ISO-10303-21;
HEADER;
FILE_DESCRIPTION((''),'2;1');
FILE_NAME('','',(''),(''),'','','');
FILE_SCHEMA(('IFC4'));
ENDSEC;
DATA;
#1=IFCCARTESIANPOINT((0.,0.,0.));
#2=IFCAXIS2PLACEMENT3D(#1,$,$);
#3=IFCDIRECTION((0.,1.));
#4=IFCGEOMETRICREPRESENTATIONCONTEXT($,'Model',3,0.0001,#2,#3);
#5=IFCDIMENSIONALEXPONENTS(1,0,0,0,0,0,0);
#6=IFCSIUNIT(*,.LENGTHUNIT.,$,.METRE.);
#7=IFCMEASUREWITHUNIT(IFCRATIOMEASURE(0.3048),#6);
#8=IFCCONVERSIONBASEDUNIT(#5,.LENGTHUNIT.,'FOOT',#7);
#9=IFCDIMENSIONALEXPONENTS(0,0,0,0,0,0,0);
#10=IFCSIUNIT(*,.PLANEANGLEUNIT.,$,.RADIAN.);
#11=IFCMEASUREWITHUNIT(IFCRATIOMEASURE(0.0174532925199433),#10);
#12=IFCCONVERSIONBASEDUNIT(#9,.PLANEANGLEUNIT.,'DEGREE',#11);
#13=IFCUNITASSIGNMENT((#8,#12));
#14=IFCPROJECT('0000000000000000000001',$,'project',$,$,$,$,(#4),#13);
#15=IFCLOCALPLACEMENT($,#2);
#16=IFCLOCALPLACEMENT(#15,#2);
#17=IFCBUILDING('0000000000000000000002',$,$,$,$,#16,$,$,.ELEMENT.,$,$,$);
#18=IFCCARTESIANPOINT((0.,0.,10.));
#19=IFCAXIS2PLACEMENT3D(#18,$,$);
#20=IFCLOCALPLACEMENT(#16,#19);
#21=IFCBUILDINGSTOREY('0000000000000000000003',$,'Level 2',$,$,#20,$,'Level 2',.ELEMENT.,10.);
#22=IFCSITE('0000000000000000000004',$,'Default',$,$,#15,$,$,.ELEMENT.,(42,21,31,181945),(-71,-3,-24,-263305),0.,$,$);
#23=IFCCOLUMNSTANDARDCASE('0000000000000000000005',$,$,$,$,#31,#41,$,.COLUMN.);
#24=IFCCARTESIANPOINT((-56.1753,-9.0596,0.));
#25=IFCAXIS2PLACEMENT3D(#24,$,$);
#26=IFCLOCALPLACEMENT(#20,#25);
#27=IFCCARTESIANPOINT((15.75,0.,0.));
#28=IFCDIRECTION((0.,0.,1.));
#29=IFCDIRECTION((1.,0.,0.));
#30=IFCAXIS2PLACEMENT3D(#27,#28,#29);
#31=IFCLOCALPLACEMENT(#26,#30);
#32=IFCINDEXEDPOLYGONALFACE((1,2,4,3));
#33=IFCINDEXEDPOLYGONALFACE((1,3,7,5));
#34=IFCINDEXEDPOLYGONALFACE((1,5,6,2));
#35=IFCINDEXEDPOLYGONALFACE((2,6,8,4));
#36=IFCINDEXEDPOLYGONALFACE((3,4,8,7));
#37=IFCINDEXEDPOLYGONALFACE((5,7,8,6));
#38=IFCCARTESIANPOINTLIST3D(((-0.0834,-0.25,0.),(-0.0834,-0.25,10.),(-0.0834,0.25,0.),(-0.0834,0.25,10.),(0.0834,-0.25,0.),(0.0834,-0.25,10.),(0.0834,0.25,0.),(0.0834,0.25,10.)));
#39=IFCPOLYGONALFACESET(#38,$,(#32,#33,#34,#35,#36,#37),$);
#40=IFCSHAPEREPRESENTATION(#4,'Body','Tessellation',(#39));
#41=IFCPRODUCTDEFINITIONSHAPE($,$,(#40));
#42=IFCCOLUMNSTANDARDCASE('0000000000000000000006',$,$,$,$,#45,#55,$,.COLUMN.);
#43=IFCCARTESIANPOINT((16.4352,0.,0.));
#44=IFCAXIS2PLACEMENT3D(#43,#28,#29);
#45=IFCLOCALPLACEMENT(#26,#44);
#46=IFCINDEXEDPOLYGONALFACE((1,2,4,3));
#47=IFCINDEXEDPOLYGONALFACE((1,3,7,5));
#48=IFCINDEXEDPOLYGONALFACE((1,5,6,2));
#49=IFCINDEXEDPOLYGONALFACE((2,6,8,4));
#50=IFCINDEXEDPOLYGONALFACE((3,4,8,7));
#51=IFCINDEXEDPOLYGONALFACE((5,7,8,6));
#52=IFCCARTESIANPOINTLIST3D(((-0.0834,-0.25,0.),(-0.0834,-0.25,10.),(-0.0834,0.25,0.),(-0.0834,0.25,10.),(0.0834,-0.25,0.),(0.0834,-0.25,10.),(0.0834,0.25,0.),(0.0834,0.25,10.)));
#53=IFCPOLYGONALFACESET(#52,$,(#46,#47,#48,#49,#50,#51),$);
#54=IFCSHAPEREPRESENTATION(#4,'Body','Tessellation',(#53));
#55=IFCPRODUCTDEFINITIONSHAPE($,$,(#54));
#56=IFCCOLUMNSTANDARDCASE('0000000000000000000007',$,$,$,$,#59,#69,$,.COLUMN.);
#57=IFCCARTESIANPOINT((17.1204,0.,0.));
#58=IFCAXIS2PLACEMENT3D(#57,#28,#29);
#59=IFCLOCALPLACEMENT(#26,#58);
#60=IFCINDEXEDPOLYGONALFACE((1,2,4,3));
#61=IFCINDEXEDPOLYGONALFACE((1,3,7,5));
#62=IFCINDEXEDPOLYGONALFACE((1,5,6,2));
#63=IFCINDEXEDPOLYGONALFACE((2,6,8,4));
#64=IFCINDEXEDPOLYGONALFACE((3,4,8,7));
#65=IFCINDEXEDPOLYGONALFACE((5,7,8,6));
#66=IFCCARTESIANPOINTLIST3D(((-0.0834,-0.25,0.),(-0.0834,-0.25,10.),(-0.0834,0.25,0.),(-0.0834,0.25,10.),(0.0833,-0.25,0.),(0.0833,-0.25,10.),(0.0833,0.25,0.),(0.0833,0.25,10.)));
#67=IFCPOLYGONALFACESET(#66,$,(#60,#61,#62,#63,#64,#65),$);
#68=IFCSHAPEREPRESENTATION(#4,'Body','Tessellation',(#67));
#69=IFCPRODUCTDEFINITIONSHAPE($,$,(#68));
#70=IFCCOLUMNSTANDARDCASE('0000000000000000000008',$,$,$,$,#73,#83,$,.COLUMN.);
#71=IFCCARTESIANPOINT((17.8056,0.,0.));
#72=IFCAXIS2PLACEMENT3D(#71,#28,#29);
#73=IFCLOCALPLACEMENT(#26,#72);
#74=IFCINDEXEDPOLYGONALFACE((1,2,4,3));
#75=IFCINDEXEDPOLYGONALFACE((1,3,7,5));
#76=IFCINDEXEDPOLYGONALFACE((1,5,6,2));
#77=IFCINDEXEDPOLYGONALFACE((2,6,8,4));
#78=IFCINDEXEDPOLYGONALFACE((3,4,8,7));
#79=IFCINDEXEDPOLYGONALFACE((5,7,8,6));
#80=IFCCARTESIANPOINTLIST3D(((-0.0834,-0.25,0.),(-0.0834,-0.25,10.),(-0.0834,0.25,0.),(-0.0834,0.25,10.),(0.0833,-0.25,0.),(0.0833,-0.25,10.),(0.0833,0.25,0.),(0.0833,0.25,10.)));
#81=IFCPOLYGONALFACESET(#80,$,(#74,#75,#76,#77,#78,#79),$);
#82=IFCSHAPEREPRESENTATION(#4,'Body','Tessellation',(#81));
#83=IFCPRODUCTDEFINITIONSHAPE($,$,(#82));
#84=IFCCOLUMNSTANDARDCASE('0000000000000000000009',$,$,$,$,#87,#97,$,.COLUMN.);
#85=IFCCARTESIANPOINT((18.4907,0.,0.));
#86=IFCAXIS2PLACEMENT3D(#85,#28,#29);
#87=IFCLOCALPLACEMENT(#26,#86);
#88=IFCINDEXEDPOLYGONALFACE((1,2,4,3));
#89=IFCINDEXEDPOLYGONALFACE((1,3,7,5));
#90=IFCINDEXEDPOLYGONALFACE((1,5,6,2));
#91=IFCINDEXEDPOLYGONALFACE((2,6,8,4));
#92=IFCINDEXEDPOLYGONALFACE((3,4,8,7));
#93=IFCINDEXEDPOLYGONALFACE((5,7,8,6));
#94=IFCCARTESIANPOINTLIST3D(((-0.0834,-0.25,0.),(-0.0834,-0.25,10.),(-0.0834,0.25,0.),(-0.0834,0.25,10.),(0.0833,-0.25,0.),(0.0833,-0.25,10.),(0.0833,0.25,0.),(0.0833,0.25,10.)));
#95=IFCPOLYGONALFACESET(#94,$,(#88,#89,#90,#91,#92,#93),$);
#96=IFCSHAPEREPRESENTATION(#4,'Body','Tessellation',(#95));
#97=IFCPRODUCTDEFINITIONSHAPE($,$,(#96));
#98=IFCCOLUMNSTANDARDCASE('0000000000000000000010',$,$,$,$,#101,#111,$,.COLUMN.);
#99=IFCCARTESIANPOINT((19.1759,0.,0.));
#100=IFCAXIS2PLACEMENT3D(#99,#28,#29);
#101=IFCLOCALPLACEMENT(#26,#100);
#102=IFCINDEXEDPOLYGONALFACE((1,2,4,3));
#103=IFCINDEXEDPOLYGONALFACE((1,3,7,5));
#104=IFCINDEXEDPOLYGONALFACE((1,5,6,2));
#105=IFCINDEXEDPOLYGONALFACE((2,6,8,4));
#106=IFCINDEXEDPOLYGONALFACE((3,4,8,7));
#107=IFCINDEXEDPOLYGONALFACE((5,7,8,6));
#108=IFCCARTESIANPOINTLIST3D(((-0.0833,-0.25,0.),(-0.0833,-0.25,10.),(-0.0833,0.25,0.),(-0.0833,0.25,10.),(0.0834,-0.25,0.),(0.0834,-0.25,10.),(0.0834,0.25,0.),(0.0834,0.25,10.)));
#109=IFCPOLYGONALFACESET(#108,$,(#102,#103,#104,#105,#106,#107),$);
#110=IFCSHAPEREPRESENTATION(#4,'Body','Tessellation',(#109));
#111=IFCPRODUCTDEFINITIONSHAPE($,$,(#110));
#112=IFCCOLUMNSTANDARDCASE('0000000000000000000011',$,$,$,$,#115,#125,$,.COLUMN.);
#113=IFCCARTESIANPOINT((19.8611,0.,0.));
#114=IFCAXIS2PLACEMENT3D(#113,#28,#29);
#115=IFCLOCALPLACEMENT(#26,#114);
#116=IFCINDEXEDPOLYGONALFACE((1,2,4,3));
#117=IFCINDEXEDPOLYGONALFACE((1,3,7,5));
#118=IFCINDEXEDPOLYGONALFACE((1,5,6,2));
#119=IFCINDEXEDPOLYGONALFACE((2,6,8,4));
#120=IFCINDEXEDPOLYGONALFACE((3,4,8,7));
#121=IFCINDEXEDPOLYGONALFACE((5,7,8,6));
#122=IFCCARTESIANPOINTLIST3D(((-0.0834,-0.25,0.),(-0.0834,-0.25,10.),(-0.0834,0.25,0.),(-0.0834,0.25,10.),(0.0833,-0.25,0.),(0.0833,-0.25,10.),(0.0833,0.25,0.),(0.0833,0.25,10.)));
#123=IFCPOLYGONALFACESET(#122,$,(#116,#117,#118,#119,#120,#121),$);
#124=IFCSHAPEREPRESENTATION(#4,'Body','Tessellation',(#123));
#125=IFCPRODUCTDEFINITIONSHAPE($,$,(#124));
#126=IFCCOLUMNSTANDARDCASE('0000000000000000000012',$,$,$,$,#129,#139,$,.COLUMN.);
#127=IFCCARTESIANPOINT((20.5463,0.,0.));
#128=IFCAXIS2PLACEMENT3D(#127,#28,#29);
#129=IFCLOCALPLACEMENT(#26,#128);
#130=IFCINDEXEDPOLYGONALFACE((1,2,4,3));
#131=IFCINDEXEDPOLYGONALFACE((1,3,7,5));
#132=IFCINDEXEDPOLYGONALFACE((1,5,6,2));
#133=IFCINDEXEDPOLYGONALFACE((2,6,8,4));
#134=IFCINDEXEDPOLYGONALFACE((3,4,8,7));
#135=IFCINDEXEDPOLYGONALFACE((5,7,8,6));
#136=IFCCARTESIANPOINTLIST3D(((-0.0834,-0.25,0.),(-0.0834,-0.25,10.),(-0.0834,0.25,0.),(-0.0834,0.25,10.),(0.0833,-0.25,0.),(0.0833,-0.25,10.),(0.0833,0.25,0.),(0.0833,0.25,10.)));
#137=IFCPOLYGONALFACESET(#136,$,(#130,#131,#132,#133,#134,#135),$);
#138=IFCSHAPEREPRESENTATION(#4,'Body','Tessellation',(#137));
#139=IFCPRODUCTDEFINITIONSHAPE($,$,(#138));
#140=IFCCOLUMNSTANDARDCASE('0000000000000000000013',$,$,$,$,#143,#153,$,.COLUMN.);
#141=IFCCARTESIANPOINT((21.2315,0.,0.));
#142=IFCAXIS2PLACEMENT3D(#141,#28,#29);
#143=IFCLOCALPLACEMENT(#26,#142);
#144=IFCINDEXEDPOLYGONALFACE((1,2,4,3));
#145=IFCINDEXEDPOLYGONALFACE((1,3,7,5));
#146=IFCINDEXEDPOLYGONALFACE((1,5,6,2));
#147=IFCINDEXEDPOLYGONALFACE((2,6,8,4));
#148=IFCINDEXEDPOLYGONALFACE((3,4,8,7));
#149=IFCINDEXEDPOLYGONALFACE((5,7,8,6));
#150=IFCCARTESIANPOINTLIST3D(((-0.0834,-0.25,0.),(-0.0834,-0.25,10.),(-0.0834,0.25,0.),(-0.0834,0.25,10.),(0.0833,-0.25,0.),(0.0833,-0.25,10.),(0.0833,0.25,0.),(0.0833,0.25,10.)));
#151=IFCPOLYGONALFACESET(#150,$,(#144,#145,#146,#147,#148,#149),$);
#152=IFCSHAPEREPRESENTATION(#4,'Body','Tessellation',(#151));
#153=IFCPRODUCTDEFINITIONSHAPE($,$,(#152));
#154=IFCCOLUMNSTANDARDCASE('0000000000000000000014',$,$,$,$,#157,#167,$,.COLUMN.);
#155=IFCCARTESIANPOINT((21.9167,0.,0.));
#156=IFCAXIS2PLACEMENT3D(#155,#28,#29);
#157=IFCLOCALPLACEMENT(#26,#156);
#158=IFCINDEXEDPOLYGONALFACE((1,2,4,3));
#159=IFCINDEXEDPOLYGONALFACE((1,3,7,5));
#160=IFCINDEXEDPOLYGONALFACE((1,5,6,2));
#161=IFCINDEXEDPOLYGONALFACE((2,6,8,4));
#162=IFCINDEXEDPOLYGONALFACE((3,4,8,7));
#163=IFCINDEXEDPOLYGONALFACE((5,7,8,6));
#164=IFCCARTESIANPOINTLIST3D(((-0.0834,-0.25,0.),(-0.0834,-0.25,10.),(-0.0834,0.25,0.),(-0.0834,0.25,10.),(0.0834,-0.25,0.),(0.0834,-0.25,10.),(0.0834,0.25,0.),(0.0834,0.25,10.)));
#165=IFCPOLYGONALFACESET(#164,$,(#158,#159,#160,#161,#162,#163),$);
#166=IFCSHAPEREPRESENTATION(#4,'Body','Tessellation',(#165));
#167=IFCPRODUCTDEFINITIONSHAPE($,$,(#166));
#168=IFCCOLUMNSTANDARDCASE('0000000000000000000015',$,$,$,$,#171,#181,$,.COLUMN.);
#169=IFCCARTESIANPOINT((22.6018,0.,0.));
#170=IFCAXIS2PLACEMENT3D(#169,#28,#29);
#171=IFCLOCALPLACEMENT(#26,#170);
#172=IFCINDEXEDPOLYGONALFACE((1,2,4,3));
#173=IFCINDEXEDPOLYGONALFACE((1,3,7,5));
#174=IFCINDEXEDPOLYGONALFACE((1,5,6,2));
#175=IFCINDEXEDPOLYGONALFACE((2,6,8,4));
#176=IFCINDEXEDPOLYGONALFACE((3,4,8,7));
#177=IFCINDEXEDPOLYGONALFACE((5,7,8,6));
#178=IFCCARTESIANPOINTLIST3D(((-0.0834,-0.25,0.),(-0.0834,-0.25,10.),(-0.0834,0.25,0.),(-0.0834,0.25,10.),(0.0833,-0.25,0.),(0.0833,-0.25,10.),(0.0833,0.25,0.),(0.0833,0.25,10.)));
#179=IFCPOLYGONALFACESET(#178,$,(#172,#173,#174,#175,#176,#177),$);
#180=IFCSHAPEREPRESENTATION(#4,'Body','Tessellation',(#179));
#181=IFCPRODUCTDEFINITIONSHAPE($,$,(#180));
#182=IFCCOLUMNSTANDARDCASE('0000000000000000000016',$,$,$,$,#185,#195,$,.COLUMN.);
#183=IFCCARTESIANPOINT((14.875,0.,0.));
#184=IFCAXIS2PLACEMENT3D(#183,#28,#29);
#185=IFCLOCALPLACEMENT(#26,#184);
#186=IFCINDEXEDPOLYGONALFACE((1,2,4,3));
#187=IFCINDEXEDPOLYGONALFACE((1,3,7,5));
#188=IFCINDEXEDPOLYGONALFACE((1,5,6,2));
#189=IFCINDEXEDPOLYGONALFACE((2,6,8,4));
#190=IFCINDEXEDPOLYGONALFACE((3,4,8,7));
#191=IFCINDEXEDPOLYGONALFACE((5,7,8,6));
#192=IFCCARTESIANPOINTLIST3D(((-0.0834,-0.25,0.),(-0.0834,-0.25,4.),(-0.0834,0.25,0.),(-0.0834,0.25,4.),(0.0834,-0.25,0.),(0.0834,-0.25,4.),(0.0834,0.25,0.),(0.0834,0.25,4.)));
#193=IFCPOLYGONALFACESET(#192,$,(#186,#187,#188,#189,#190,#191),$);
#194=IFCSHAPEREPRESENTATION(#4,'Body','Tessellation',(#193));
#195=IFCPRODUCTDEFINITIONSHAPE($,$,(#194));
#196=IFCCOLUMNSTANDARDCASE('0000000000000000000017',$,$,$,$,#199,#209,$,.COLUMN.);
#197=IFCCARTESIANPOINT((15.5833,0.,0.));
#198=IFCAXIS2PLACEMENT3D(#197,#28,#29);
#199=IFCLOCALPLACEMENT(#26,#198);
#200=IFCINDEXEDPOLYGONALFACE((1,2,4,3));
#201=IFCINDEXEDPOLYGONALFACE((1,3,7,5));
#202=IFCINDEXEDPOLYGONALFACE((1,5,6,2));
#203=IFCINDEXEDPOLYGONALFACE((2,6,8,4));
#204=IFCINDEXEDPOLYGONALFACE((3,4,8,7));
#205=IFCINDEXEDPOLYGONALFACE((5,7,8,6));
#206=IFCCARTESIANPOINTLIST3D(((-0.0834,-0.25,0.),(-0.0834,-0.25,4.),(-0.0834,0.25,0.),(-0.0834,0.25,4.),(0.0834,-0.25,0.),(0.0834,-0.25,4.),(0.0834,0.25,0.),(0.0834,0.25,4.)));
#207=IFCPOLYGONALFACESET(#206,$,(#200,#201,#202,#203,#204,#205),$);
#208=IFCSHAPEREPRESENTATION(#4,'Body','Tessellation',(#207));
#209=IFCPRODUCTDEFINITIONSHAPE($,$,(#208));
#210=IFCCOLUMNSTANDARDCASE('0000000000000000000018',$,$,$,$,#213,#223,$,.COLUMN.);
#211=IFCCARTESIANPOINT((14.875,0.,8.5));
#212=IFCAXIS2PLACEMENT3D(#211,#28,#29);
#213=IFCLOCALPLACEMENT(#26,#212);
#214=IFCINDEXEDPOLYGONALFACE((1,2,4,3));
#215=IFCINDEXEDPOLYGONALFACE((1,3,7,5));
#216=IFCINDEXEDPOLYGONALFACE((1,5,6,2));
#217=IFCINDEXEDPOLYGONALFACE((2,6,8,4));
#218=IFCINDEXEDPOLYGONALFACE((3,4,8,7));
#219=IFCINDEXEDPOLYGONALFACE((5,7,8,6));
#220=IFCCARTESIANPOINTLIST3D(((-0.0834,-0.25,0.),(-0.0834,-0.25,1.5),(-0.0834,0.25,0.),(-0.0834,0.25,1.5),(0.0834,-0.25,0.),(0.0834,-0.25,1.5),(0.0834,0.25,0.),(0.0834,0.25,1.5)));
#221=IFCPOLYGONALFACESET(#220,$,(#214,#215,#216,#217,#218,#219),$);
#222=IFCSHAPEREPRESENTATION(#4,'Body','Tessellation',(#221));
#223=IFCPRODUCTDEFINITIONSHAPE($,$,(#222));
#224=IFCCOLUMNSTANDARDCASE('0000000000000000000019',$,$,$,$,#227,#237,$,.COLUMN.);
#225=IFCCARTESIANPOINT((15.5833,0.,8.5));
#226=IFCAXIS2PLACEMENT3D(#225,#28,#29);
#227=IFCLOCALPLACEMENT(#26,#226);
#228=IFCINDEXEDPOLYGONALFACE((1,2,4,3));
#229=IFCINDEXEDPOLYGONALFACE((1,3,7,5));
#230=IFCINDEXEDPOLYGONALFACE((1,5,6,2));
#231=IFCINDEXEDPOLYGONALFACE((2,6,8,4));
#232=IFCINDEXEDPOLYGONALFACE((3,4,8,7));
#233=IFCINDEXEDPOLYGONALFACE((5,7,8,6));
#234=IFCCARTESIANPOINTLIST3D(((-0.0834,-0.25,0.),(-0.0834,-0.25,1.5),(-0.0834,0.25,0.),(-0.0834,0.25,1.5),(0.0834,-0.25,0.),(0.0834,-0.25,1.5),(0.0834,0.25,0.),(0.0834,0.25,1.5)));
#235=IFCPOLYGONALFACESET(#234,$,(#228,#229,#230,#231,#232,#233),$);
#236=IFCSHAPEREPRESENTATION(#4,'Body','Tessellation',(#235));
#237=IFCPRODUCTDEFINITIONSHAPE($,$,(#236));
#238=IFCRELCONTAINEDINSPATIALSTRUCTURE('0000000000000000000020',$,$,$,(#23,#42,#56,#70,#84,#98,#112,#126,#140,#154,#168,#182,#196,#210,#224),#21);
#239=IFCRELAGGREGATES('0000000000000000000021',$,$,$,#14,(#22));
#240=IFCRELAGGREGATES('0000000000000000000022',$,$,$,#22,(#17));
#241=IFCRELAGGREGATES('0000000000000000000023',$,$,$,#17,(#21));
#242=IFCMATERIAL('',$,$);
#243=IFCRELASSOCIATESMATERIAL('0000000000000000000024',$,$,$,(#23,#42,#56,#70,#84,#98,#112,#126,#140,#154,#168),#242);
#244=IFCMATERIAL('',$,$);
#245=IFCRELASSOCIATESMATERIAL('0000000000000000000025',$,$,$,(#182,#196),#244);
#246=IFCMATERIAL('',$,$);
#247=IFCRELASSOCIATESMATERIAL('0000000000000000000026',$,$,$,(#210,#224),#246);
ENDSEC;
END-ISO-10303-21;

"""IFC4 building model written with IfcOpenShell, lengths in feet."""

from ifc_helpers import new_model, entity, si_unit, converted_unit, direction, frame, origin, place, context, project, spatial, rectangle, extrude, material, element, save


model = new_model("IFC4")

# Units and contexts
model_context = context("Model", 3, precision=0.0001, world=origin(), true_north=direction((0.0, 1.0)))
ifc_project = project(units=[converted_unit("LENGTHUNIT", "FOOT", entity("IfcRatioMeasure", 0.3048), si_unit("LENGTHUNIT", "METRE"), dimensions=[1, 0, 0, 0, 0, 0, 0]), converted_unit("PLANEANGLEUNIT", "DEGREE", entity("IfcRatioMeasure", 0.0174532925199433), si_unit("PLANEANGLEUNIT", "RADIAN"), dimensions=[0, 0, 0, 0, 0, 0, 0])], contexts=[model_context])

# Site, building, storey
site_placement = place(None, origin())
site = spatial("IfcSite", under=ifc_project, at=site_placement, Name="Default", CompositionType="ELEMENT", RefLatitude=(42, 21, 31, 181945), RefLongitude=(-71, -3, -24, -263305), RefElevation=0.0)
building_placement = place(site_placement, origin())
building = spatial("IfcBuilding", under=site, at=building_placement, CompositionType="ELEMENT")
storey_placement = place(building_placement, frame((0.0, 0.0, 10.0)))
storey = spatial("IfcBuildingStorey", under=building, at=storey_placement, Name="Level 2", LongName="Level 2", CompositionType="ELEMENT", Elevation=10.0)

# Columns
ifc_material_1 = material(Name="")
placement = place(storey_placement, frame((-56.1753, -9.0596, 0.0)))
for number, where, z_axis, x_axis in (
    (1, (15.75, 0.0, 0.0), (0.0, 0.0, 1.0), (1.0, 0.0, 0.0)),
    (2, (16.4352, 0.0, 0.0), (0.0, 0.0, 1.0), (1.0, 0.0, 0.0)),
    (3, (17.1204, 0.0, 0.0), (0.0, 0.0, 1.0), (1.0, 0.0, 0.0)),
    (4, (17.8056, 0.0, 0.0), (0.0, 0.0, 1.0), (1.0, 0.0, 0.0)),
    (5, (18.4907, 0.0, 0.0), (0.0, 0.0, 1.0), (1.0, 0.0, 0.0)),
    (6, (19.1759, 0.0, 0.0), (0.0, 0.0, 1.0), (1.0, 0.0, 0.0)),
    (7, (19.8611, 0.0, 0.0), (0.0, 0.0, 1.0), (1.0, 0.0, 0.0)),
    (8, (20.5463, 0.0, 0.0), (0.0, 0.0, 1.0), (1.0, 0.0, 0.0)),
    (9, (21.2315, 0.0, 0.0), (0.0, 0.0, 1.0), (1.0, 0.0, 0.0)),
    (10, (21.9167, 0.0, 0.0), (0.0, 0.0, 1.0), (1.0, 0.0, 0.0)),
    (11, (22.6018, 0.0, 0.0), (0.0, 0.0, 1.0), (1.0, 0.0, 0.0)),
):
    element("IfcColumnStandardCase", number, at=place(placement, frame(where, z_axis=z_axis, x_axis=x_axis)), inside=storey, material=ifc_material_1, PredefinedType="COLUMN", context=model_context, shape_type="SweptSolid", body=[
        extrude(rectangle(XDim=0.1667, YDim=0.5), origin(), (0.0, 0.0, 1.0), 10.0),
    ])
ifc_material_2 = material(Name="")
for number, where, z_axis, x_axis in (
    (12, (14.875, 0.0, 0.0), (0.0, 0.0, 1.0), (1.0, 0.0, 0.0)),
    (13, (15.5833, 0.0, 0.0), (0.0, 0.0, 1.0), (1.0, 0.0, 0.0)),
):
    element("IfcColumnStandardCase", number, at=place(placement, frame(where, z_axis=z_axis, x_axis=x_axis)), inside=storey, material=ifc_material_2, PredefinedType="COLUMN", context=model_context, shape_type="SweptSolid", body=[
        extrude(rectangle(XDim=0.1667, YDim=0.5), origin(), (0.0, 0.0, 1.0), 4.0),
    ])
ifc_material_3 = material(Name="")
for number, where, z_axis, x_axis in (
    (14, (14.875, 0.0, 8.5), (0.0, 0.0, 1.0), (1.0, 0.0, 0.0)),
    (15, (15.5833, 0.0, 8.5), (0.0, 0.0, 1.0), (1.0, 0.0, 0.0)),
):
    element("IfcColumnStandardCase", number, at=place(placement, frame(where, z_axis=z_axis, x_axis=x_axis)), inside=storey, material=ifc_material_3, PredefinedType="COLUMN", context=model_context, shape_type="SweptSolid", body=[
        extrude(rectangle(XDim=0.1667, YDim=0.5), origin(), (0.0, 0.0, 1.0), 1.5),
    ])

save(model, "model.ifc")
